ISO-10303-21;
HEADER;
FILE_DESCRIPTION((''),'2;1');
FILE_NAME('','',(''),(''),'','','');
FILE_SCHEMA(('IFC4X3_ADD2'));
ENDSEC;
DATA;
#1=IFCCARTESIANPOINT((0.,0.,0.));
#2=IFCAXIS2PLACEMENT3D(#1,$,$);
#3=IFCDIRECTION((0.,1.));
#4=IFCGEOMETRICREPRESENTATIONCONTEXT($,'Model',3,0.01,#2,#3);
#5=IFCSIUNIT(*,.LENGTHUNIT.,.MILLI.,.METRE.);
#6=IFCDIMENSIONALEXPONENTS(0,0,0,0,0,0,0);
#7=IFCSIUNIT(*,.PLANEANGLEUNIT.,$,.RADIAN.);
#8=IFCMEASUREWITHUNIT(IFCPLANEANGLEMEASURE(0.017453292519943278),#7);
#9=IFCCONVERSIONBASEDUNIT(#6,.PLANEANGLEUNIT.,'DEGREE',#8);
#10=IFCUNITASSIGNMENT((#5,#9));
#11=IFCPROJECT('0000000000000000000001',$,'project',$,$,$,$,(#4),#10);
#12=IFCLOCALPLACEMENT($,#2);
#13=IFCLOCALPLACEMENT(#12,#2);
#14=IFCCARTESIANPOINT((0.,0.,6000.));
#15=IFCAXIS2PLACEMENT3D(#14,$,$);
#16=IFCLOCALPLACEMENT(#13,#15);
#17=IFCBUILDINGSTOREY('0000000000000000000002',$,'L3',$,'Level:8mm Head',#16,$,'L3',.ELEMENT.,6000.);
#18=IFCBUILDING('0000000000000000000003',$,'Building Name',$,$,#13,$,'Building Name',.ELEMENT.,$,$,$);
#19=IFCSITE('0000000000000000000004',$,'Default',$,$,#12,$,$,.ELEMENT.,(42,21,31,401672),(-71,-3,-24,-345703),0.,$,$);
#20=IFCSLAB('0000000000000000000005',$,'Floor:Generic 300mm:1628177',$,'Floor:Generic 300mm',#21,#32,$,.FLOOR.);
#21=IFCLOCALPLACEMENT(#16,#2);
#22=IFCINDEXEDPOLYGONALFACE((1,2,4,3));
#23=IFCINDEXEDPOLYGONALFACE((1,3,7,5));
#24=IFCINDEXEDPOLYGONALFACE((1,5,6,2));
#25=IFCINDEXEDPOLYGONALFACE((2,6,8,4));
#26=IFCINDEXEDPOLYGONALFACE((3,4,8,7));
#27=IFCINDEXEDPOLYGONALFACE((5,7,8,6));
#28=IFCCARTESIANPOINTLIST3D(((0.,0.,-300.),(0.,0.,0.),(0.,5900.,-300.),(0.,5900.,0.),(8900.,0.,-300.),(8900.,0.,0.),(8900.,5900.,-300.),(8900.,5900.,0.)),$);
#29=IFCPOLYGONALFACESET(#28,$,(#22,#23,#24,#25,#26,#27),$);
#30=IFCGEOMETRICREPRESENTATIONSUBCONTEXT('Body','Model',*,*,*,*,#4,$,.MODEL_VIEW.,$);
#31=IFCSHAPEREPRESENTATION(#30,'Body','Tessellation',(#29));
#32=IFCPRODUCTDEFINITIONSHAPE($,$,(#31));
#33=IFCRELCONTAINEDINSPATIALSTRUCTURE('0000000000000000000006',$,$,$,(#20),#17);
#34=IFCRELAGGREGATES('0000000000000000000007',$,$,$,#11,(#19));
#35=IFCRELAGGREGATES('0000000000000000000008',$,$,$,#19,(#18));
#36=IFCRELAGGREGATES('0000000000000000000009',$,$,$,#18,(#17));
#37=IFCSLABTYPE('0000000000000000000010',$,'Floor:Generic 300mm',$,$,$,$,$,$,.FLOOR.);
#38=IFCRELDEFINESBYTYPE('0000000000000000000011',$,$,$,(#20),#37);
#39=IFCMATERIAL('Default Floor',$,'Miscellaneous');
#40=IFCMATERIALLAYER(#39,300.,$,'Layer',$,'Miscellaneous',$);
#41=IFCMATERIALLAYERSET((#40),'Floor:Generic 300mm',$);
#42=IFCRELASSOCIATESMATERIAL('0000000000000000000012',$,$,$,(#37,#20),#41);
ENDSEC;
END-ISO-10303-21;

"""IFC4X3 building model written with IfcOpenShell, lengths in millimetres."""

from ifc_helpers import new_model, entity, si_unit, converted_unit, direction, frame, frame_2d, origin, place, context, subcontext, project, spatial, rectangle, extrude, material, layer, layer_set, layer_usage, type_object, element, save


model = new_model("IFC4X3")

# Units and contexts
model_context = context("Model", 3, precision=0.01, world=origin(), true_north=direction((0.0, 1.0)))
body_context = subcontext(model_context, "Body", "Model", "MODEL_VIEW")
ifc_project = project(units=[si_unit("LENGTHUNIT", "METRE", prefix="MILLI"), converted_unit("PLANEANGLEUNIT", "DEGREE", entity("IfcPlaneAngleMeasure", 0.017453292519943278), si_unit("PLANEANGLEUNIT", "RADIAN"), dimensions=[0, 0, 0, 0, 0, 0, 0])], contexts=[model_context])

# Site, building, storey
site_placement = place(None, origin())
site = spatial("IfcSite", under=ifc_project, at=site_placement, Name="Default", CompositionType="ELEMENT", RefLatitude=(42, 21, 31, 401672), RefLongitude=(-71, -3, -24, -345703), RefElevation=0.0)
building_placement = place(site_placement, origin())
building = spatial("IfcBuilding", under=site, at=building_placement, Name="Building Name", LongName="Building Name", CompositionType="ELEMENT")
storey_placement = place(building_placement, frame((0.0, 0.0, 6000.0)))
storey = spatial("IfcBuildingStorey", under=building, at=storey_placement, Name="L3", ObjectType="Level:8mm Head", LongName="L3", CompositionType="ELEMENT", Elevation=6000.0)

# Slab
ifc_material = material(Name="Default Floor", Category="Miscellaneous")
ifc_layer = layer(ifc_material, 300.0, Name="Layer", Category="Miscellaneous")
ifc_layer_set = layer_set([ifc_layer], Name="Floor:Generic 300mm")
ifc_layer_usage = layer_usage(ifc_layer_set, "AXIS3", "POSITIVE", 0.0)
slab_type = type_object("IfcSlabType", Name="Floor:Generic 300mm", PredefinedType="FLOOR", material=ifc_layer_set)
slab_placement = place(storey_placement, origin())
element("IfcSlab", 1, at=slab_placement, inside=storey, type_object=slab_type, material=ifc_layer_usage, Name="Floor:Generic 300mm:1628177", ObjectType="Floor:Generic 300mm", PredefinedType="FLOOR", context=body_context, shape_type="SweptSolid", body=[
    extrude(rectangle(XDim=5900.0, YDim=8900.0, at=frame_2d((0.0, 0.0), x_axis=(1.0, 0.0))), frame((4450.0, 2950.0, 0.0), z_axis=(0.0, 0.0, -1.0), x_axis=(0.0, 1.0, 0.0)), (0.0, 0.0, 1.0), 300.0),
])

save(model, "model.ifc")
